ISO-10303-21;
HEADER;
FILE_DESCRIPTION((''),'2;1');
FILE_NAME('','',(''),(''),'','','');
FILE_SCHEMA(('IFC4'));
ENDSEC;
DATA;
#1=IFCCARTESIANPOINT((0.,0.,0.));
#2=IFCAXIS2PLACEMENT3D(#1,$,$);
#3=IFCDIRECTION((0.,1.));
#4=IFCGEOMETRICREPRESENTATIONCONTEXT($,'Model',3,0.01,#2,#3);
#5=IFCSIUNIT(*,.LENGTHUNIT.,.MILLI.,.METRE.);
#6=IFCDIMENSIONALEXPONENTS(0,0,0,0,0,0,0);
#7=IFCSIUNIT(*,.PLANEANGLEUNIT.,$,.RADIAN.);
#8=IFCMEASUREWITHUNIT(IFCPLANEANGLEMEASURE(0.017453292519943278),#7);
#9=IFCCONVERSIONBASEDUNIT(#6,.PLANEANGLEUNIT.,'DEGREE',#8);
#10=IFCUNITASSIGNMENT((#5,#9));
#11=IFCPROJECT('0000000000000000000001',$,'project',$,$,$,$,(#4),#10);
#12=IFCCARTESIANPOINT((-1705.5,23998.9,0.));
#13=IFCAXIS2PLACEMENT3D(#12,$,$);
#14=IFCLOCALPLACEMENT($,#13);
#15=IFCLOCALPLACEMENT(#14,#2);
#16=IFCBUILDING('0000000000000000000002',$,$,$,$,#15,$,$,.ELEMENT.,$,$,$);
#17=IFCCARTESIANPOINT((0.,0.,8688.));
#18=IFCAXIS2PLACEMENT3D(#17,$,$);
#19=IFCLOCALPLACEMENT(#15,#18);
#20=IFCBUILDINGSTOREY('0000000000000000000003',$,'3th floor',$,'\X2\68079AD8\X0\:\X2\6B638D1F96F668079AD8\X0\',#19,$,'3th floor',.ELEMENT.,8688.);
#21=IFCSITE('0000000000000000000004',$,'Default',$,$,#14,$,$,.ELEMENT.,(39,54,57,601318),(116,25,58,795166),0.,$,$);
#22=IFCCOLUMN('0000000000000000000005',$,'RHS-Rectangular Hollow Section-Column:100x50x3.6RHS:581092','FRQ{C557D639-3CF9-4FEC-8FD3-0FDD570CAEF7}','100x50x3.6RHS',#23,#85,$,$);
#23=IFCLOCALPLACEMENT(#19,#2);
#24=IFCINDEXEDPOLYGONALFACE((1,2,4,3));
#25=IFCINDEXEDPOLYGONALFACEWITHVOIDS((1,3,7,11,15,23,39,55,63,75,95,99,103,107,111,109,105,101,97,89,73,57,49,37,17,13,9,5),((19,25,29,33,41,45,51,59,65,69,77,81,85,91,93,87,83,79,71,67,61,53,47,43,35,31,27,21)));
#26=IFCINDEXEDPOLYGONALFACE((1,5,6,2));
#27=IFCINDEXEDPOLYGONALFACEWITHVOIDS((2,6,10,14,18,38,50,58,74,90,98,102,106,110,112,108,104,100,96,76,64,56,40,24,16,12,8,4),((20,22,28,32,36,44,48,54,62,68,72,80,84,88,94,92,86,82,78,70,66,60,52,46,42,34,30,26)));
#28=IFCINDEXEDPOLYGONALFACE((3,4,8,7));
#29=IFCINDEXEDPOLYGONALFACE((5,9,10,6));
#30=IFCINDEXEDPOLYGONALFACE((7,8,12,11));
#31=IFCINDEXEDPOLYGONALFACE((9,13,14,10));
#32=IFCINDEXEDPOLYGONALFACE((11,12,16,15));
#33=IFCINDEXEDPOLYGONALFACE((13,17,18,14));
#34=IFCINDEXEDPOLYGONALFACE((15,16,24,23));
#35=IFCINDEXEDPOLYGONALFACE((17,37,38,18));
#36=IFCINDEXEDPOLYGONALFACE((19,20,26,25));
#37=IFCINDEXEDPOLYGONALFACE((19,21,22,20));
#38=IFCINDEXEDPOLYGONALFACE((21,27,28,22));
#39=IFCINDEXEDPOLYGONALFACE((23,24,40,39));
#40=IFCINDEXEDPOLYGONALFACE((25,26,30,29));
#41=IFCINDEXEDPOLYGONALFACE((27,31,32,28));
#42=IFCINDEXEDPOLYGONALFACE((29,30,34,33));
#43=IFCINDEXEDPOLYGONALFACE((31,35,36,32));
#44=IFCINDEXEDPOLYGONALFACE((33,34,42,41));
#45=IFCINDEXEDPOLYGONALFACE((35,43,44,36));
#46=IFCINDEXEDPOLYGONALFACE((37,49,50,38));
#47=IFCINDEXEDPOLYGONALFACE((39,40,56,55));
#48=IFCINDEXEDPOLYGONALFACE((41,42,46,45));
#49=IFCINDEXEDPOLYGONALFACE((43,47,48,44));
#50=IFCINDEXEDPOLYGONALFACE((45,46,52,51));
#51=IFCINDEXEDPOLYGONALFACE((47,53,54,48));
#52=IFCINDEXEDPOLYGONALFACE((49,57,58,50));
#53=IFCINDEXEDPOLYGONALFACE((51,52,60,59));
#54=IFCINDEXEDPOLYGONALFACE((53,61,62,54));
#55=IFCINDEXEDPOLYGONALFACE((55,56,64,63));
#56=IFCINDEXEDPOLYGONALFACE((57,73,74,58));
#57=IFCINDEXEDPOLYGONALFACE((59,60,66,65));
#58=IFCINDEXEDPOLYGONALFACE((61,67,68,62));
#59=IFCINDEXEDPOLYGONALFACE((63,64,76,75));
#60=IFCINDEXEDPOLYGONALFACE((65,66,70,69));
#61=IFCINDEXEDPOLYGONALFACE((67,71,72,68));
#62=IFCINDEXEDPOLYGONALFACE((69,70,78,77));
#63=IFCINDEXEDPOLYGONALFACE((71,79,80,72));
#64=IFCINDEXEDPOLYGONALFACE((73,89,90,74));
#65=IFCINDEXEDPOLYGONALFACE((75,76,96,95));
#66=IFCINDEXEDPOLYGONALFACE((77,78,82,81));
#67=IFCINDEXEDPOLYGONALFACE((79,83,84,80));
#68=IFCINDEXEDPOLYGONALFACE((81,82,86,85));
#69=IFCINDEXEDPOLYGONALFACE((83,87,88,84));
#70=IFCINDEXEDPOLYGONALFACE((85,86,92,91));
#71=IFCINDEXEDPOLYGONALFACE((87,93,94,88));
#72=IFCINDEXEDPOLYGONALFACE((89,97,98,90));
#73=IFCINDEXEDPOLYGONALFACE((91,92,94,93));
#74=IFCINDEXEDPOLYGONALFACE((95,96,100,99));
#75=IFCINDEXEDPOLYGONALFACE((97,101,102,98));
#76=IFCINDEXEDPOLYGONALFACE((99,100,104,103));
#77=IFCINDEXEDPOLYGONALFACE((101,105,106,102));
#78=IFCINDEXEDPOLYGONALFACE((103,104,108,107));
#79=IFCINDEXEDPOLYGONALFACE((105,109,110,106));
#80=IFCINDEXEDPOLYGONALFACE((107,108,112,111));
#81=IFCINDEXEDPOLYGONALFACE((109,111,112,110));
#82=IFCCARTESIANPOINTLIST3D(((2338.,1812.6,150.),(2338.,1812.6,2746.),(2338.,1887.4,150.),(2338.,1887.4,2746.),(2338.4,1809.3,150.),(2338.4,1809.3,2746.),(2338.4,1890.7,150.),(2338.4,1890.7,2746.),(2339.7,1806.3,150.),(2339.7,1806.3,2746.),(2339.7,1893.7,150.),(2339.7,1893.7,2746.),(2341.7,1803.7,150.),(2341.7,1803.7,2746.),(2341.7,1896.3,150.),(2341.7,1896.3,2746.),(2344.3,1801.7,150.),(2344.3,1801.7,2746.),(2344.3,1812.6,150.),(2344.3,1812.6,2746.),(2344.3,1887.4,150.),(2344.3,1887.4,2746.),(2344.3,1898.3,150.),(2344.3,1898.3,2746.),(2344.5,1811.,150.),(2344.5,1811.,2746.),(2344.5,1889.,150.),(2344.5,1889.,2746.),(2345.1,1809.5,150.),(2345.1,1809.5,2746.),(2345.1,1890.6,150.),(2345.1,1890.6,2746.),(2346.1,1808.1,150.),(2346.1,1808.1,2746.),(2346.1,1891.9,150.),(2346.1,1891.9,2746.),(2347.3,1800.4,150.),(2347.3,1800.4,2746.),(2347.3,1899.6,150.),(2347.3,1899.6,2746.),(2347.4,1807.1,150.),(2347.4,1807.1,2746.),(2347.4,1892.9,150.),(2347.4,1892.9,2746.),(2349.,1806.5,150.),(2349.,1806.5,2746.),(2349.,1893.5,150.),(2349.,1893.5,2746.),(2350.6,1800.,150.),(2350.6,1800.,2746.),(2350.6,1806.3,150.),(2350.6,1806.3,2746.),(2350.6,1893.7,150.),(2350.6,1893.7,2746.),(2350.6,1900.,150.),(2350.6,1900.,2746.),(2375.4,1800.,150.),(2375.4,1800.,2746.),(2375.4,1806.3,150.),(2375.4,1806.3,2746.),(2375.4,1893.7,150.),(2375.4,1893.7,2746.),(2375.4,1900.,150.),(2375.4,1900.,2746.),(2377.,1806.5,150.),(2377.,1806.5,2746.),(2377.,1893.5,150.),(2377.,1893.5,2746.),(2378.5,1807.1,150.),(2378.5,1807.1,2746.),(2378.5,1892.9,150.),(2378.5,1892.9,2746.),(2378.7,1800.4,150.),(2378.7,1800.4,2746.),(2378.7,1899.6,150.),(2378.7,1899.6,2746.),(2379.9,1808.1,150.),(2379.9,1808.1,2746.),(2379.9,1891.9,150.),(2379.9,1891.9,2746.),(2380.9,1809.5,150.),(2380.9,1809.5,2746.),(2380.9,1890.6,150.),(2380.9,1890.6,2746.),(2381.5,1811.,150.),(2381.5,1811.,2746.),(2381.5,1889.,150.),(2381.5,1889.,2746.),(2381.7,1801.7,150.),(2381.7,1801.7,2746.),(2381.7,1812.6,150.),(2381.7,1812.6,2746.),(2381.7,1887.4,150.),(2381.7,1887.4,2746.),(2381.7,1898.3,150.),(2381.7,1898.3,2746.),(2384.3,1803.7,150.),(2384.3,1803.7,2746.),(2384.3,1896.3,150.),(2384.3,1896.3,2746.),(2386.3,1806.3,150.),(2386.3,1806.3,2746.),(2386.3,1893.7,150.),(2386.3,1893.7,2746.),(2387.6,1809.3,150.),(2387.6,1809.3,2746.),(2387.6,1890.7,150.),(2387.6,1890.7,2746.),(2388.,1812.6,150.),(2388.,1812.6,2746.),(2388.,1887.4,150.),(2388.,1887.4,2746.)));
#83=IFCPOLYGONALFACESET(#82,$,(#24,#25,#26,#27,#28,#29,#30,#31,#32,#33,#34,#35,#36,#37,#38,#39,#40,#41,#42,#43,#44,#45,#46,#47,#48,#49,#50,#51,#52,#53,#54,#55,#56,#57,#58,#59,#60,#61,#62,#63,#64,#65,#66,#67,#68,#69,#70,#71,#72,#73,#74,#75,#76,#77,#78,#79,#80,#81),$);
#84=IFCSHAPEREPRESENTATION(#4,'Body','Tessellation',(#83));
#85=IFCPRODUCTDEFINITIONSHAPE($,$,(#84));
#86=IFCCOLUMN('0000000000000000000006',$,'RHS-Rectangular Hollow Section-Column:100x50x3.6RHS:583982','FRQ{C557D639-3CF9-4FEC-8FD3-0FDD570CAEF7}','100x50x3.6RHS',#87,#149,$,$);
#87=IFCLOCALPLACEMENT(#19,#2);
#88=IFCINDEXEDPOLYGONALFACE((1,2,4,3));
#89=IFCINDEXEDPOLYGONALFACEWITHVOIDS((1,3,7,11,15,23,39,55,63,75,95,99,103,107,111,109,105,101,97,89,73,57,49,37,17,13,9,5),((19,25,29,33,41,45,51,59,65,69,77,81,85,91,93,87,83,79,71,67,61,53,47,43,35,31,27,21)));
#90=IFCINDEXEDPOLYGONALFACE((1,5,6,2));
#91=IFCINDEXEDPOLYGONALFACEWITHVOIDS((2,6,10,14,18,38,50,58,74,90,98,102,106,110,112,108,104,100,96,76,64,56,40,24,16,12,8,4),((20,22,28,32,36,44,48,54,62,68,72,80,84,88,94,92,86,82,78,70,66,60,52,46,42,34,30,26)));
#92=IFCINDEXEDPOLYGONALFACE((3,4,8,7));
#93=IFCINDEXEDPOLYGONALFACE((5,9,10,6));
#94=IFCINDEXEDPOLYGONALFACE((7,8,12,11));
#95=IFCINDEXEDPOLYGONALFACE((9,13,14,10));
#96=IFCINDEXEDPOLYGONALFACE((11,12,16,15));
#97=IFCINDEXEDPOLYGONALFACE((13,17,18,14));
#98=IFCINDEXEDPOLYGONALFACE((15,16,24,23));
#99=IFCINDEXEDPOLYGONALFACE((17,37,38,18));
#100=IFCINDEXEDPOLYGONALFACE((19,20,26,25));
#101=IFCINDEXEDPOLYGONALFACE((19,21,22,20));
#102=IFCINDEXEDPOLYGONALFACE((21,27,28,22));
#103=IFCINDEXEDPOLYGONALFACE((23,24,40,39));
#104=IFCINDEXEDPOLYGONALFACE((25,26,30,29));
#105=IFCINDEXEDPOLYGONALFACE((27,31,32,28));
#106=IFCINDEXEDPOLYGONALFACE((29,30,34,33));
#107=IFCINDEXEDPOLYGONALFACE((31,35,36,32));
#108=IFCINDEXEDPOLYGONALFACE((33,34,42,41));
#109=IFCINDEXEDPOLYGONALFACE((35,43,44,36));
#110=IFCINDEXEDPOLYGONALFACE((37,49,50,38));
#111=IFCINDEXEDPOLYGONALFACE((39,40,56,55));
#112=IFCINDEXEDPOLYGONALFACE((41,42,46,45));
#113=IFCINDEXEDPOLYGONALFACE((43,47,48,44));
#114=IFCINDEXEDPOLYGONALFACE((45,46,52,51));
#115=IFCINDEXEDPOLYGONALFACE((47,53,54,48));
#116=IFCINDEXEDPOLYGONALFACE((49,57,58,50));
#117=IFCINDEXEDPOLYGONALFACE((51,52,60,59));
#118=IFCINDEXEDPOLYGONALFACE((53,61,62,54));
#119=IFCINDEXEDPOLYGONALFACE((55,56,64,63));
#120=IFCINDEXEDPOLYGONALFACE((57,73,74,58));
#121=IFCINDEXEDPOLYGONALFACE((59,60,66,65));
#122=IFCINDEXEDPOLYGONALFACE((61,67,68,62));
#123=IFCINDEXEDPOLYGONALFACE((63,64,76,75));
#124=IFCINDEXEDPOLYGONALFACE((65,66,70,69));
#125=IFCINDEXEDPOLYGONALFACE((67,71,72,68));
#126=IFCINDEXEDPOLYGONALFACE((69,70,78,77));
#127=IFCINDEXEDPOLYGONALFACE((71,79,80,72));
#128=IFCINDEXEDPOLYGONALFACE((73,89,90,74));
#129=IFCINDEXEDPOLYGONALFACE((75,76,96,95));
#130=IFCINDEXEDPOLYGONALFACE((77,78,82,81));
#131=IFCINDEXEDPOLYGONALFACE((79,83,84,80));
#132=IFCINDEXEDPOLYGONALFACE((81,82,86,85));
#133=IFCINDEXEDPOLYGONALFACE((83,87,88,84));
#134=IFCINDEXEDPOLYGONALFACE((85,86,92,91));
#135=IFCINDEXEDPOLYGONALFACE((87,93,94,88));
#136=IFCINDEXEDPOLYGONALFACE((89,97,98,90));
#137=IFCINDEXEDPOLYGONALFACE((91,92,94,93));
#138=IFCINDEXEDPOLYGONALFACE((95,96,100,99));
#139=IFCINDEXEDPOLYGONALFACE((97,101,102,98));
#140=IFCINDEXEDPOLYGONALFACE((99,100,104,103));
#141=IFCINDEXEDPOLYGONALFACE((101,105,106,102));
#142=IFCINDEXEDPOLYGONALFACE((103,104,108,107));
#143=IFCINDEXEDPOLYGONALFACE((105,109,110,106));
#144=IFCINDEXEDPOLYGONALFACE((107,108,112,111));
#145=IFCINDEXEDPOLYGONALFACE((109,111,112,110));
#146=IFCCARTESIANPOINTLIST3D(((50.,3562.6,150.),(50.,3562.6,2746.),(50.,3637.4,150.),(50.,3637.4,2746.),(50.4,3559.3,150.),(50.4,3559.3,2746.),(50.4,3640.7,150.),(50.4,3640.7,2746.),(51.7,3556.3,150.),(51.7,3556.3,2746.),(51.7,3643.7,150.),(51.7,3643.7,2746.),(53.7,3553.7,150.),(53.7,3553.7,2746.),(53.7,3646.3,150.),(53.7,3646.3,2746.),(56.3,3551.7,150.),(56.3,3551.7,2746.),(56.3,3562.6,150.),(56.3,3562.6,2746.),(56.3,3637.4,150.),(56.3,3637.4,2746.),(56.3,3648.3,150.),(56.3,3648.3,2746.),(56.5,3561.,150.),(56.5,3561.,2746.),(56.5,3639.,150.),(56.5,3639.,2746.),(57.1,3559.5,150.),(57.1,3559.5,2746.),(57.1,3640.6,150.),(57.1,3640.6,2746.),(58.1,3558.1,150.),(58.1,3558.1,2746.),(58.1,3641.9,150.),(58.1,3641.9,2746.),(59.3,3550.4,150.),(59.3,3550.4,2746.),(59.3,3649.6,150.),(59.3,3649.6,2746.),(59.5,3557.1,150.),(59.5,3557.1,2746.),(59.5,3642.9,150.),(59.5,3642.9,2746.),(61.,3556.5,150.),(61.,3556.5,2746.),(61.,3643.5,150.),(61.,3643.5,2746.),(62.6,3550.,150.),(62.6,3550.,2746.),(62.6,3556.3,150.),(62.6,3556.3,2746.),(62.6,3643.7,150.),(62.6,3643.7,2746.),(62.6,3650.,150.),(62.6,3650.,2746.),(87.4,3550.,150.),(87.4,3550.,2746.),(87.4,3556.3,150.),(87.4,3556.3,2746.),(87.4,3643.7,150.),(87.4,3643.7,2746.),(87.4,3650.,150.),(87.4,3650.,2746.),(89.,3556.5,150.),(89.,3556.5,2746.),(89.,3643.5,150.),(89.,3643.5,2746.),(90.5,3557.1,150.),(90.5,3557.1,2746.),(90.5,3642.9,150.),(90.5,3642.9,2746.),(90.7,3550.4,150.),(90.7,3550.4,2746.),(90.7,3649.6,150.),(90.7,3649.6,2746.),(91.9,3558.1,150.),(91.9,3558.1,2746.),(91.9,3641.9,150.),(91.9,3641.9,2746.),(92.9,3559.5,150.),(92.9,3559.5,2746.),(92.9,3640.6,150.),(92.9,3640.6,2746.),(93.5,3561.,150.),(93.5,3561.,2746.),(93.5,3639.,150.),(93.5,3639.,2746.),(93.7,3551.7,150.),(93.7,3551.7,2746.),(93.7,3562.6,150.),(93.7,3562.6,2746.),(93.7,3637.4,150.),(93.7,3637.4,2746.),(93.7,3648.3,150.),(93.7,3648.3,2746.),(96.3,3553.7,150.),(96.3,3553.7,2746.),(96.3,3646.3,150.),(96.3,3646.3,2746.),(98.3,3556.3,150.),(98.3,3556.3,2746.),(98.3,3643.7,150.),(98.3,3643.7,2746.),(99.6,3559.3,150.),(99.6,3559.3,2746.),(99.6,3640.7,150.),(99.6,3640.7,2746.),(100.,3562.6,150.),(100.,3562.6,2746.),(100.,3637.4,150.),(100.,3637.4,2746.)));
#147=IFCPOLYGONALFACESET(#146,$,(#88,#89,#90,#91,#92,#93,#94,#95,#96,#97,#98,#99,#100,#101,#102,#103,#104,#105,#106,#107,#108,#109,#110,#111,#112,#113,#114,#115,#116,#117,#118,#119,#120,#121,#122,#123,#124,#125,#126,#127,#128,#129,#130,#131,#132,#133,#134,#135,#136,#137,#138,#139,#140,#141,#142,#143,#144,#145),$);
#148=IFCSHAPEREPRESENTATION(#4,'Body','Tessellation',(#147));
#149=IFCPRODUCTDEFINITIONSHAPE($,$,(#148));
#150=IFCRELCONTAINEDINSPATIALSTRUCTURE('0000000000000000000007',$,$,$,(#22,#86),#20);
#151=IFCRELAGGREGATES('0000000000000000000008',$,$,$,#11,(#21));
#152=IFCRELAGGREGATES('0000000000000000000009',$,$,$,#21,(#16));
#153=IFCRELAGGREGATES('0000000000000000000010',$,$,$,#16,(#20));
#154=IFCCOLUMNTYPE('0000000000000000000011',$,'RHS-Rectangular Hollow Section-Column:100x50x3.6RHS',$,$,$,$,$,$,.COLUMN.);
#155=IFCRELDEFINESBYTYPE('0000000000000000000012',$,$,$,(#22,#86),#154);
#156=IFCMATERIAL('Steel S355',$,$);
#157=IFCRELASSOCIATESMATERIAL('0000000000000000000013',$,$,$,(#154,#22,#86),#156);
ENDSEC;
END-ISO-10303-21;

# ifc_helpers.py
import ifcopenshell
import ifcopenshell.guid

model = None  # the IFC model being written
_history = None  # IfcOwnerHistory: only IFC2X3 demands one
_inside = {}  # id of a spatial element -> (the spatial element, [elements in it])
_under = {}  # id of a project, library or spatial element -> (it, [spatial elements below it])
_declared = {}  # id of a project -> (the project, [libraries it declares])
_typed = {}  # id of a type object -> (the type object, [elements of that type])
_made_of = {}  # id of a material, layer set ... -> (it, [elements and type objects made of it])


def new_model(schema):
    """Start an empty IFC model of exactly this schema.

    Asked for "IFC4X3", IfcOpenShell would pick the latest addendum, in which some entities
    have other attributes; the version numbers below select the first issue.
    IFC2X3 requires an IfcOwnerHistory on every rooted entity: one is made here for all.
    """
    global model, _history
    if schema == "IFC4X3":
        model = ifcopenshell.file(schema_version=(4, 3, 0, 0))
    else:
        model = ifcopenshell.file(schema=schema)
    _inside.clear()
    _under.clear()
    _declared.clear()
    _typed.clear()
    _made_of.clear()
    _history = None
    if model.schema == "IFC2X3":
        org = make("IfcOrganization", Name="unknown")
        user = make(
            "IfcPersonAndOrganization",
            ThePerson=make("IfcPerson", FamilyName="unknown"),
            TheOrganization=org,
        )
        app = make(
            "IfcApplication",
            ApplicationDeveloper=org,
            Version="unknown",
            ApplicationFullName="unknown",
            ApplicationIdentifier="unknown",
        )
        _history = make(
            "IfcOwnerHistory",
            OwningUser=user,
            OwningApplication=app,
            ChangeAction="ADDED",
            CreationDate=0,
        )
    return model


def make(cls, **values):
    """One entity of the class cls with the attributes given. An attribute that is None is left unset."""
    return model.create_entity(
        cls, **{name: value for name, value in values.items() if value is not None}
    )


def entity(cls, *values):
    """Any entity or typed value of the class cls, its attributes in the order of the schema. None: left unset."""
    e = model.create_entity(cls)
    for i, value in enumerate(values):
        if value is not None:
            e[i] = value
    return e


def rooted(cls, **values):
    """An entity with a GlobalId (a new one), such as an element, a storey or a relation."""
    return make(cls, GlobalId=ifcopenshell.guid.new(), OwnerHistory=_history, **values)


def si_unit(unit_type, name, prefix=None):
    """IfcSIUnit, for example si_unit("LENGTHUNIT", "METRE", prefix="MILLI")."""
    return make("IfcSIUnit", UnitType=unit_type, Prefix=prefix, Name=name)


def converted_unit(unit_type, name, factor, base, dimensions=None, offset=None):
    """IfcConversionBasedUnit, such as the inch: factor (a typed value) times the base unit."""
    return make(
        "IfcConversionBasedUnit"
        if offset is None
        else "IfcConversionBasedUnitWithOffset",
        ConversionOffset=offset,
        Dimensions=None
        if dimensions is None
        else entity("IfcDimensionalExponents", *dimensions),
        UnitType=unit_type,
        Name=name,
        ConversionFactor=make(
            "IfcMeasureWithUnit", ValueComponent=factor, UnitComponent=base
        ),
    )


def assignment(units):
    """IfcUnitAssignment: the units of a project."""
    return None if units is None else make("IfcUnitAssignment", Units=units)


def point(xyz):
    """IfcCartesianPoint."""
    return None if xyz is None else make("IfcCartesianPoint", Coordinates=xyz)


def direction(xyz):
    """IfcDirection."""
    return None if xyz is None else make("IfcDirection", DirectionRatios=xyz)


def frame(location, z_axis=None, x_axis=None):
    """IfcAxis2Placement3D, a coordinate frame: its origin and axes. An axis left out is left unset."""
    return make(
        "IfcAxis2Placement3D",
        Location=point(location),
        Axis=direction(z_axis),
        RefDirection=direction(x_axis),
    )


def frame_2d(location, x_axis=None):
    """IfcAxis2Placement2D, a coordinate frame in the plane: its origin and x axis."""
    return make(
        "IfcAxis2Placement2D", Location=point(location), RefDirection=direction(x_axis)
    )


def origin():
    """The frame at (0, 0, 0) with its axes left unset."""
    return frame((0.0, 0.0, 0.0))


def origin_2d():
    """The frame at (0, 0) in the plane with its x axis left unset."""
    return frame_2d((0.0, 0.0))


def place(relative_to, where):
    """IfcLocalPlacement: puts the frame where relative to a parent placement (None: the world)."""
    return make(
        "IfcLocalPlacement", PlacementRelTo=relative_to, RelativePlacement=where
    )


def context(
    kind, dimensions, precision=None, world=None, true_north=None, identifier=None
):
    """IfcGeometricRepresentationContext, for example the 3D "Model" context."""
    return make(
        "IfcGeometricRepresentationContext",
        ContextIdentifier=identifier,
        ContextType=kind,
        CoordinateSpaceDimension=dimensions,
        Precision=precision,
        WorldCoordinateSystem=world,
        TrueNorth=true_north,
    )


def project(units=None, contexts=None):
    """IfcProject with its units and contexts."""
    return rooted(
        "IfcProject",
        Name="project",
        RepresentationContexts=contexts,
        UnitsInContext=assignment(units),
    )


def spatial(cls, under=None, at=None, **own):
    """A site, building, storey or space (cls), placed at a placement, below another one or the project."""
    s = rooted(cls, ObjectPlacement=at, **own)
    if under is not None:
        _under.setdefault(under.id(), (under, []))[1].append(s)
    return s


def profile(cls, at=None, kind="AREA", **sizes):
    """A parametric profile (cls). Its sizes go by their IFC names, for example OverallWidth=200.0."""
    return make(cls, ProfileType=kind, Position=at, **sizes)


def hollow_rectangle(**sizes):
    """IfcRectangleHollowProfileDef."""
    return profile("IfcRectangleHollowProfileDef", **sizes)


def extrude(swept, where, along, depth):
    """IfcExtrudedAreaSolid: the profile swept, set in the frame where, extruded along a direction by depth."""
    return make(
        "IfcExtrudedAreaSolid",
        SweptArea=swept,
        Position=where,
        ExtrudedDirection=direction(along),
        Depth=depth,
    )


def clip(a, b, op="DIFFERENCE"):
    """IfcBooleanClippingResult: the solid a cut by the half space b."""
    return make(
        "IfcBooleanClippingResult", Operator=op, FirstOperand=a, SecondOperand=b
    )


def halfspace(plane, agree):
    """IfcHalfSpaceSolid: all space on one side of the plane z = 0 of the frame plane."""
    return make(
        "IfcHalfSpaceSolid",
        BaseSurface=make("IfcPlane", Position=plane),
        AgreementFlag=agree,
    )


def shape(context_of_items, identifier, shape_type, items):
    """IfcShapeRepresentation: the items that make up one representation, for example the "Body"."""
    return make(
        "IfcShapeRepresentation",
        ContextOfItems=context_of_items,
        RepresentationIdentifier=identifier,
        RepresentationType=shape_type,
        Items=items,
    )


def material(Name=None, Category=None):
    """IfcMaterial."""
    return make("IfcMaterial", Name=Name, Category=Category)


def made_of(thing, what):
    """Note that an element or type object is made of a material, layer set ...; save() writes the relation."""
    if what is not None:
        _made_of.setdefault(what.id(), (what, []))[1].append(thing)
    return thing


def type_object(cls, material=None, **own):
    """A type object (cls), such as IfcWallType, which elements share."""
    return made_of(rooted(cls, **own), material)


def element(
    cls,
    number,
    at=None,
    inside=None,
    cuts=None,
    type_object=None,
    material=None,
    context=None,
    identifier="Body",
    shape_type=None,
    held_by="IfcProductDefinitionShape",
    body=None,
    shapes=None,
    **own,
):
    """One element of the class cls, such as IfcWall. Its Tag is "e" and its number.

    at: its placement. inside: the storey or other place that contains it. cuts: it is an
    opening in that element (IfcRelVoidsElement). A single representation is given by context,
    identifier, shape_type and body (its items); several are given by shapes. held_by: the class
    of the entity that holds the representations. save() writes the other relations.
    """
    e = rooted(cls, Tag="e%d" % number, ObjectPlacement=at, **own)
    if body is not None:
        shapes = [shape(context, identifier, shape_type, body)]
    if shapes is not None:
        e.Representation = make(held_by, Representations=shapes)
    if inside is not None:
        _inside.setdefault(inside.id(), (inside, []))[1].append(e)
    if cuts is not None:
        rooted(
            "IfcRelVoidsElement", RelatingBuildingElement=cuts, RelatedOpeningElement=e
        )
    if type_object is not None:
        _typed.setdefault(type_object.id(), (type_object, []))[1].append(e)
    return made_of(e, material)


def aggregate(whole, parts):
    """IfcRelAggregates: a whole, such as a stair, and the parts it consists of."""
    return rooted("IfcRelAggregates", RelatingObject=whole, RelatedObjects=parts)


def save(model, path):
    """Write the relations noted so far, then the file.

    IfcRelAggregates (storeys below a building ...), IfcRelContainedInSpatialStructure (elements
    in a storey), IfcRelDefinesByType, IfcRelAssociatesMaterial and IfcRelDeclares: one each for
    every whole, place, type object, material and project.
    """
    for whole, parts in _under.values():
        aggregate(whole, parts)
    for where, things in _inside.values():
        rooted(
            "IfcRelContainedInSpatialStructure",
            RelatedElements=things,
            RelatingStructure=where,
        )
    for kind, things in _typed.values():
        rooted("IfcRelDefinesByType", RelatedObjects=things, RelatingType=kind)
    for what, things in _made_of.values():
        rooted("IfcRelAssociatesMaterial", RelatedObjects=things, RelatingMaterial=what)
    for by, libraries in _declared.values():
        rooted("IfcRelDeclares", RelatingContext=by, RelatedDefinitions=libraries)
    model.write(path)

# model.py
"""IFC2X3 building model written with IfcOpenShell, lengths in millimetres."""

from ifc_helpers import new_model, entity, si_unit, converted_unit, direction, frame, origin, origin_2d, place, context, project, spatial, hollow_rectangle, extrude, clip, halfspace, material, type_object, element, save


model = new_model("IFC2X3")

# Units and contexts
model_context = context("Model", 3, precision=0.01, world=origin(), true_north=direction((0.0, 1.0)))
ifc_project = project(units=[si_unit("LENGTHUNIT", "METRE", prefix="MILLI"), converted_unit("PLANEANGLEUNIT", "DEGREE", entity("IfcPlaneAngleMeasure", 0.017453292519943278), si_unit("PLANEANGLEUNIT", "RADIAN"), dimensions=[0, 0, 0, 0, 0, 0, 0])], contexts=[model_context])

# Site, building, storey
site_placement = place(None, frame((-1705.5, 23998.9, 0.0)))
site = spatial("IfcSite", under=ifc_project, at=site_placement, Name="Default", CompositionType="ELEMENT", RefLatitude=(39, 54, 57, 601318), RefLongitude=(116, 25, 58, 795166), RefElevation=0.0)
building_placement = place(site_placement, origin())
building = spatial("IfcBuilding", under=site, at=building_placement, CompositionType="ELEMENT")
storey_placement = place(building_placement, frame((0.0, 0.0, 8688.0)))
storey = spatial("IfcBuildingStorey", under=building, at=storey_placement, Name="3th floor", ObjectType="标高:正负零标高", LongName="3th floor", CompositionType="ELEMENT", Elevation=8688.0)

# Columns
ifc_material = material(Name="Steel S355")
column_type_1 = type_object("IfcColumnType", Name="RHS-Rectangular Hollow Section-Column:100x50x3.6RHS", PredefinedType="COLUMN", material=ifc_material)
column_1_placement = place(storey_placement, frame((2363.0, 1850.0, 2746.0), z_axis=(0.0, 0.0, 1.0), x_axis=(-1.0, 0.0, 0.0)))
element("IfcColumn", 1, at=column_1_placement, inside=storey, type_object=column_type_1, material=ifc_material, Name="RHS-Rectangular Hollow Section-Column:100x50x3.6RHS:581092", Description="FRQ{C557D639-3CF9-4FEC-8FD3-0FDD570CAEF7}", ObjectType="100x50x3.6RHS", context=model_context, shape_type="Clipping", body=[
    clip(extrude(hollow_rectangle(XDim=50.0, YDim=100.0, WallThickness=6.3, InnerFilletRadius=6.3, OuterFilletRadius=12.6, at=origin_2d()), origin(), (0.0, 0.0, -1.0), 2651.9), halfspace(frame((2363.0, 1850.0, -2596.0), z_axis=(0.0, 0.0, 1.0), x_axis=(-1.0, 0.0, 0.0)), True)),
])
column_2_placement = place(storey_placement, frame((75.0, 3600.0, 2746.0), z_axis=(0.0, 0.0, 1.0), x_axis=(-1.0, 0.0, 0.0)))
element("IfcColumn", 2, at=column_2_placement, inside=storey, type_object=column_type_1, material=ifc_material, Name="RHS-Rectangular Hollow Section-Column:100x50x3.6RHS:583982", Description="FRQ{C557D639-3CF9-4FEC-8FD3-0FDD570CAEF7}", ObjectType="100x50x3.6RHS", context=model_context, shape_type="Clipping", body=[
    clip(extrude(hollow_rectangle(XDim=50.0, YDim=100.0, WallThickness=6.3, InnerFilletRadius=6.3, OuterFilletRadius=12.6, at=origin_2d()), origin(), (0.0, 0.0, -1.0), 2651.9), halfspace(frame((75.0, 3600.0, -2596.0), z_axis=(0.0, 0.0, 1.0), x_axis=(-1.0, 0.0, 0.0)), True)),
])

save(model, "model.ifc")
